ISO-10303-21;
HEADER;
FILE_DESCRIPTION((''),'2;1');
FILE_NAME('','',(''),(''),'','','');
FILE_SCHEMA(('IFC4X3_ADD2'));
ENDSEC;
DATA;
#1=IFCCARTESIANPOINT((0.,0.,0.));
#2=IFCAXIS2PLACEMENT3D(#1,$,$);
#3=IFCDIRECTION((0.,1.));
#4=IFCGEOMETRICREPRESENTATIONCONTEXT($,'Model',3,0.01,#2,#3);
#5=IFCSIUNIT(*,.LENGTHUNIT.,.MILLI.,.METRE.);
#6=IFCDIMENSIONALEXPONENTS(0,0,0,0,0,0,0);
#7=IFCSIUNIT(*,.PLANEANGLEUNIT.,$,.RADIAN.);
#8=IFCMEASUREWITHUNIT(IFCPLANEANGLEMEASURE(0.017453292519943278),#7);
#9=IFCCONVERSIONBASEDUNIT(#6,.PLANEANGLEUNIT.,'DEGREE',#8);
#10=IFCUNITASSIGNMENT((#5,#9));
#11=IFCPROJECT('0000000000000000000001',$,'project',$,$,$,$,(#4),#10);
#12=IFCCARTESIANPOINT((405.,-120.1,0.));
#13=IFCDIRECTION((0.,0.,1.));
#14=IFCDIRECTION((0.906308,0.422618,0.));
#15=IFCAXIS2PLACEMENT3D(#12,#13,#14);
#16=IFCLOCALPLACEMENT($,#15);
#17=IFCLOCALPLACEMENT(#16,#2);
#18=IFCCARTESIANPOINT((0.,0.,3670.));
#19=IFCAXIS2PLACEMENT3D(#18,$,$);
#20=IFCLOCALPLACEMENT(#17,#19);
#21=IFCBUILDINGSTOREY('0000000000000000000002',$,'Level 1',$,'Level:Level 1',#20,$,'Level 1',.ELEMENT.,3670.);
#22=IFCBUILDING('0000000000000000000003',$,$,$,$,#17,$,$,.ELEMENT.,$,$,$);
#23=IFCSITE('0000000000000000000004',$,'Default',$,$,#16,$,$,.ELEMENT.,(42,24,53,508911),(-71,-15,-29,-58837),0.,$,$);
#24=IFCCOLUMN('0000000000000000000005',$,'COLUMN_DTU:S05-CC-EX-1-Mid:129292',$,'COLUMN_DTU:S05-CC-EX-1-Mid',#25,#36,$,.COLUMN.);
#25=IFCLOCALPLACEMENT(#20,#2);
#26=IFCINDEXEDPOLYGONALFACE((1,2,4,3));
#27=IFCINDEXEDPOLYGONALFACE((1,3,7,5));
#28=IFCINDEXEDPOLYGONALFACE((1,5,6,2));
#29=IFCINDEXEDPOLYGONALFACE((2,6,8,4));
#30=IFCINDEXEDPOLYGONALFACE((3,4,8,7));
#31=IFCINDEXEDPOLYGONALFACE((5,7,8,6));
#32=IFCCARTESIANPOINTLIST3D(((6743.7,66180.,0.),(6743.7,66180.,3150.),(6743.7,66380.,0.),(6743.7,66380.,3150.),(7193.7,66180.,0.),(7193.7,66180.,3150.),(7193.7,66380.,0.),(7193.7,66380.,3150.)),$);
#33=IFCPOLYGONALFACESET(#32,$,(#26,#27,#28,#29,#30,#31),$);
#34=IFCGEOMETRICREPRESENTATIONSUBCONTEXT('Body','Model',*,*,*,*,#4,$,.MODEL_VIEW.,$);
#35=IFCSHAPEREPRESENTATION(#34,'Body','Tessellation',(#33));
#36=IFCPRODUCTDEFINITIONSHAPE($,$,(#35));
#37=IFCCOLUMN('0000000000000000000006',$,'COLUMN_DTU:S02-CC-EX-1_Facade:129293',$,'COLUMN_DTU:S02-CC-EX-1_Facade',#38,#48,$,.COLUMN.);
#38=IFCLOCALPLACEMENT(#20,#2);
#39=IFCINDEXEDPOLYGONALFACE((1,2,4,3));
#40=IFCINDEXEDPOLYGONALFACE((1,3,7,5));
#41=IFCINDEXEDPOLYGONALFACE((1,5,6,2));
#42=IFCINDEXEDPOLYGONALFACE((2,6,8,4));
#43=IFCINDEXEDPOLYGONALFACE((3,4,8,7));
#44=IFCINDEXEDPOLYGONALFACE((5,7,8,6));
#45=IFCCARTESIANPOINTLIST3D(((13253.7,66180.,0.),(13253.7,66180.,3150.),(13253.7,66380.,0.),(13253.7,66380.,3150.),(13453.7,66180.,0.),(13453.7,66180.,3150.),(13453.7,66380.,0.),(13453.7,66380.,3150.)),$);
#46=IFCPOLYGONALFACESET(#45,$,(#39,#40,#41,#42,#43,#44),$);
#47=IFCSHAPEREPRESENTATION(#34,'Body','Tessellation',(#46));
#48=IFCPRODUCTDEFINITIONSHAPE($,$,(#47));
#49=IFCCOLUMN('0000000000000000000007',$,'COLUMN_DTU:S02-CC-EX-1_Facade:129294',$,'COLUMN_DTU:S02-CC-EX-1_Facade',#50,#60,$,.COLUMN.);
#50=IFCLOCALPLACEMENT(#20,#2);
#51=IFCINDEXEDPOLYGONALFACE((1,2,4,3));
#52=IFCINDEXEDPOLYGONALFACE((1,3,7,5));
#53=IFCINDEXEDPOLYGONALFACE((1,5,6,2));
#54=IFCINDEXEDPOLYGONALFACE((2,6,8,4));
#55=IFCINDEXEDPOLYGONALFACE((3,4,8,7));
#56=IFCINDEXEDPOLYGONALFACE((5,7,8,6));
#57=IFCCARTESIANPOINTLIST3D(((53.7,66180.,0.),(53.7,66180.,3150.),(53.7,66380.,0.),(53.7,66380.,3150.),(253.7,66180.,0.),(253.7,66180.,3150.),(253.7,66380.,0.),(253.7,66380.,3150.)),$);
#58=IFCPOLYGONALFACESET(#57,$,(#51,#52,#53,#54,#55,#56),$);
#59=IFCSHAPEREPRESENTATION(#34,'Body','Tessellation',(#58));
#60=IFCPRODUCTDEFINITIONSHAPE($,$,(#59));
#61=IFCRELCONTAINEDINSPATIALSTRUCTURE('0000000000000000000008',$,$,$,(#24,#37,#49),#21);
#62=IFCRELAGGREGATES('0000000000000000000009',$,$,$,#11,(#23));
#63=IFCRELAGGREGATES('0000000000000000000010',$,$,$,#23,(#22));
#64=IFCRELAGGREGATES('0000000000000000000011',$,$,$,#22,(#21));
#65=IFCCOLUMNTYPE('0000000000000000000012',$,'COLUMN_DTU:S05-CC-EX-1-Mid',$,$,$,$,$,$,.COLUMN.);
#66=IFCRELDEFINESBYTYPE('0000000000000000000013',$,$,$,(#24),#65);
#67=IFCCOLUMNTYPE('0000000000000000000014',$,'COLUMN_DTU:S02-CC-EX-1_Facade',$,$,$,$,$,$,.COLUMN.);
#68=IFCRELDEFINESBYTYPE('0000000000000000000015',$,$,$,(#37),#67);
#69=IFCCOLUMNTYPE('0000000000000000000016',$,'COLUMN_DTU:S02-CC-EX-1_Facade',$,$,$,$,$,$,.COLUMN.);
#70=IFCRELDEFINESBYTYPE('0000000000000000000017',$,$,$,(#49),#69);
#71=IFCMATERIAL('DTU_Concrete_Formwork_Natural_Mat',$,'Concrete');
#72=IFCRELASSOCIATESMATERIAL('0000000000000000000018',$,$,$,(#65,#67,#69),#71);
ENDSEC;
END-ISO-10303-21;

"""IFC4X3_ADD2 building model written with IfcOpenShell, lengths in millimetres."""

from ifc_helpers import new_model, entity, si_unit, converted_unit, direction, frame, frame_2d, origin, origin_2d_with_axis, place, context, subcontext, project, spatial, rectangle, extrude, source, transform, mapped, material, material_profile, profile_set, type_object, type_shapes, element, save


model = new_model("IFC4X3_ADD2")

# Units and contexts
model_context = context("Model", 3, precision=0.01, world=origin(), true_north=direction((0.0, 1.0)))
body_context = subcontext(model_context, "Body", "Model", "MODEL_VIEW")
ifc_project = project(units=[si_unit("LENGTHUNIT", "METRE", prefix="MILLI"), converted_unit("PLANEANGLEUNIT", "DEGREE", entity("IfcPlaneAngleMeasure", 0.017453292519943278), si_unit("PLANEANGLEUNIT", "RADIAN"), dimensions=[0, 0, 0, 0, 0, 0, 0])], contexts=[model_context])

# Site, building, storey
site_placement = place(None, frame((405.0, -120.1, 0.0), z_axis=(0.0, 0.0, 1.0), x_axis=(0.906308, 0.422618, 0.0)))
site = spatial("IfcSite", under=ifc_project, at=site_placement, Name="Default", CompositionType="ELEMENT", RefLatitude=(42, 24, 53, 508911), RefLongitude=(-71, -15, -29, -58837), RefElevation=0.0)
building_placement = place(site_placement, origin())
building = spatial("IfcBuilding", under=site, at=building_placement, CompositionType="ELEMENT")
storey_placement = place(building_placement, frame((0.0, 0.0, 3670.0)))
storey = spatial("IfcBuildingStorey", under=building, at=storey_placement, Name="Level 1", ObjectType="Level:Level 1", LongName="Level 1", CompositionType="ELEMENT", Elevation=3670.0)

# Columns
ifc_material = material(Name="DTU_Concrete_Formwork_Natural_Mat", Category="Concrete")
ifc_material_profile_1 = material_profile(ifc_material, rectangle(XDim=200.0, YDim=450.0, at=origin_2d_with_axis()), Name="S05-CC-EX-1-Mid")
ifc_profile_set_1 = profile_set([ifc_material_profile_1], Name="S05-CC-EX-1-Mid")
ifc_material_profile_2 = material_profile(ifc_material, rectangle(XDim=200.0, YDim=200.0, at=frame_2d((0.0, 0.0), x_axis=(1.0, 0.0))), Name="S02-CC-EX-1_Facade")
ifc_profile_set_2 = profile_set([ifc_material_profile_2], Name="S02-CC-EX-1_Facade")
column_type_1 = type_object("IfcColumnType", Name="COLUMN_DTU:S05-CC-EX-1-Mid", PredefinedType="COLUMN", material=ifc_profile_set_1)
shared_shape_1 = source(origin(), body_context, "Body", "SweptSolid", [
    extrude(rectangle(XDim=200.0, YDim=450.0, at=frame_2d((0.0, 0.0), x_axis=(1.0, 0.0))), frame((6968.7, 66280.0, 3670.0), z_axis=(0.0, 0.0, 1.0), x_axis=(0.0, 1.0, 0.0)), (0.0, 0.0, 1.0), 3150.0),
])
type_shapes(column_type_1, [shared_shape_1])
column_1_placement = place(storey_placement, frame((0.0, 0.0, -3670.0)))
element("IfcColumn", 1, at=column_1_placement, inside=storey, type_object=column_type_1, Name="COLUMN_DTU:S05-CC-EX-1-Mid:129292", ObjectType="COLUMN_DTU:S05-CC-EX-1-Mid", PredefinedType="COLUMN", context=body_context, shape_type="MappedRepresentation", body=[
    mapped(shared_shape_1, transform((0.0, 0.0, 0.0), scale=1.0)),
])
column_type_2 = type_object("IfcColumnType", Name="COLUMN_DTU:S02-CC-EX-1_Facade", PredefinedType="COLUMN", material=ifc_profile_set_2)
shared_shape_2 = source(origin(), body_context, "Body", "SweptSolid", [
    extrude(rectangle(XDim=200.0, YDim=200.0, at=frame_2d((0.0, 0.0), x_axis=(1.0, 0.0))), frame((13353.7, 66280.0, 3670.0), z_axis=(0.0, 0.0, 1.0), x_axis=(0.0, -1.0, 0.0)), (0.0, 0.0, 1.0), 3150.0),
])
type_shapes(column_type_2, [shared_shape_2])
column_2_placement = place(storey_placement, frame((0.0, 0.0, -3670.0)))
element("IfcColumn", 2, at=column_2_placement, inside=storey, type_object=column_type_2, Name="COLUMN_DTU:S02-CC-EX-1_Facade:129293", ObjectType="COLUMN_DTU:S02-CC-EX-1_Facade", PredefinedType="COLUMN", context=body_context, shape_type="MappedRepresentation", body=[
    mapped(shared_shape_2, transform((0.0, 0.0, 0.0), scale=1.0)),
])
column_type_3 = type_object("IfcColumnType", Name="COLUMN_DTU:S02-CC-EX-1_Facade", PredefinedType="COLUMN", material=ifc_profile_set_2)
shared_shape_3 = source(origin(), body_context, "Body", "SweptSolid", [
    extrude(rectangle(XDim=200.0, YDim=200.0, at=frame_2d((0.0, 0.0), x_axis=(1.0, 0.0))), frame((153.7, 66280.0, 3670.0), z_axis=(0.0, 0.0, 1.0), x_axis=(0.0, -1.0, 0.0)), (0.0, 0.0, 1.0), 3150.0),
])
type_shapes(column_type_3, [shared_shape_3])
column_3_placement = place(storey_placement, frame((0.0, 0.0, -3670.0)))
element("IfcColumn", 3, at=column_3_placement, inside=storey, type_object=column_type_3, Name="COLUMN_DTU:S02-CC-EX-1_Facade:129294", ObjectType="COLUMN_DTU:S02-CC-EX-1_Facade", PredefinedType="COLUMN", context=body_context, shape_type="MappedRepresentation", body=[
    mapped(shared_shape_3, transform((0.0, 0.0, 0.0), scale=1.0)),
])

save(model, "model.ifc")
